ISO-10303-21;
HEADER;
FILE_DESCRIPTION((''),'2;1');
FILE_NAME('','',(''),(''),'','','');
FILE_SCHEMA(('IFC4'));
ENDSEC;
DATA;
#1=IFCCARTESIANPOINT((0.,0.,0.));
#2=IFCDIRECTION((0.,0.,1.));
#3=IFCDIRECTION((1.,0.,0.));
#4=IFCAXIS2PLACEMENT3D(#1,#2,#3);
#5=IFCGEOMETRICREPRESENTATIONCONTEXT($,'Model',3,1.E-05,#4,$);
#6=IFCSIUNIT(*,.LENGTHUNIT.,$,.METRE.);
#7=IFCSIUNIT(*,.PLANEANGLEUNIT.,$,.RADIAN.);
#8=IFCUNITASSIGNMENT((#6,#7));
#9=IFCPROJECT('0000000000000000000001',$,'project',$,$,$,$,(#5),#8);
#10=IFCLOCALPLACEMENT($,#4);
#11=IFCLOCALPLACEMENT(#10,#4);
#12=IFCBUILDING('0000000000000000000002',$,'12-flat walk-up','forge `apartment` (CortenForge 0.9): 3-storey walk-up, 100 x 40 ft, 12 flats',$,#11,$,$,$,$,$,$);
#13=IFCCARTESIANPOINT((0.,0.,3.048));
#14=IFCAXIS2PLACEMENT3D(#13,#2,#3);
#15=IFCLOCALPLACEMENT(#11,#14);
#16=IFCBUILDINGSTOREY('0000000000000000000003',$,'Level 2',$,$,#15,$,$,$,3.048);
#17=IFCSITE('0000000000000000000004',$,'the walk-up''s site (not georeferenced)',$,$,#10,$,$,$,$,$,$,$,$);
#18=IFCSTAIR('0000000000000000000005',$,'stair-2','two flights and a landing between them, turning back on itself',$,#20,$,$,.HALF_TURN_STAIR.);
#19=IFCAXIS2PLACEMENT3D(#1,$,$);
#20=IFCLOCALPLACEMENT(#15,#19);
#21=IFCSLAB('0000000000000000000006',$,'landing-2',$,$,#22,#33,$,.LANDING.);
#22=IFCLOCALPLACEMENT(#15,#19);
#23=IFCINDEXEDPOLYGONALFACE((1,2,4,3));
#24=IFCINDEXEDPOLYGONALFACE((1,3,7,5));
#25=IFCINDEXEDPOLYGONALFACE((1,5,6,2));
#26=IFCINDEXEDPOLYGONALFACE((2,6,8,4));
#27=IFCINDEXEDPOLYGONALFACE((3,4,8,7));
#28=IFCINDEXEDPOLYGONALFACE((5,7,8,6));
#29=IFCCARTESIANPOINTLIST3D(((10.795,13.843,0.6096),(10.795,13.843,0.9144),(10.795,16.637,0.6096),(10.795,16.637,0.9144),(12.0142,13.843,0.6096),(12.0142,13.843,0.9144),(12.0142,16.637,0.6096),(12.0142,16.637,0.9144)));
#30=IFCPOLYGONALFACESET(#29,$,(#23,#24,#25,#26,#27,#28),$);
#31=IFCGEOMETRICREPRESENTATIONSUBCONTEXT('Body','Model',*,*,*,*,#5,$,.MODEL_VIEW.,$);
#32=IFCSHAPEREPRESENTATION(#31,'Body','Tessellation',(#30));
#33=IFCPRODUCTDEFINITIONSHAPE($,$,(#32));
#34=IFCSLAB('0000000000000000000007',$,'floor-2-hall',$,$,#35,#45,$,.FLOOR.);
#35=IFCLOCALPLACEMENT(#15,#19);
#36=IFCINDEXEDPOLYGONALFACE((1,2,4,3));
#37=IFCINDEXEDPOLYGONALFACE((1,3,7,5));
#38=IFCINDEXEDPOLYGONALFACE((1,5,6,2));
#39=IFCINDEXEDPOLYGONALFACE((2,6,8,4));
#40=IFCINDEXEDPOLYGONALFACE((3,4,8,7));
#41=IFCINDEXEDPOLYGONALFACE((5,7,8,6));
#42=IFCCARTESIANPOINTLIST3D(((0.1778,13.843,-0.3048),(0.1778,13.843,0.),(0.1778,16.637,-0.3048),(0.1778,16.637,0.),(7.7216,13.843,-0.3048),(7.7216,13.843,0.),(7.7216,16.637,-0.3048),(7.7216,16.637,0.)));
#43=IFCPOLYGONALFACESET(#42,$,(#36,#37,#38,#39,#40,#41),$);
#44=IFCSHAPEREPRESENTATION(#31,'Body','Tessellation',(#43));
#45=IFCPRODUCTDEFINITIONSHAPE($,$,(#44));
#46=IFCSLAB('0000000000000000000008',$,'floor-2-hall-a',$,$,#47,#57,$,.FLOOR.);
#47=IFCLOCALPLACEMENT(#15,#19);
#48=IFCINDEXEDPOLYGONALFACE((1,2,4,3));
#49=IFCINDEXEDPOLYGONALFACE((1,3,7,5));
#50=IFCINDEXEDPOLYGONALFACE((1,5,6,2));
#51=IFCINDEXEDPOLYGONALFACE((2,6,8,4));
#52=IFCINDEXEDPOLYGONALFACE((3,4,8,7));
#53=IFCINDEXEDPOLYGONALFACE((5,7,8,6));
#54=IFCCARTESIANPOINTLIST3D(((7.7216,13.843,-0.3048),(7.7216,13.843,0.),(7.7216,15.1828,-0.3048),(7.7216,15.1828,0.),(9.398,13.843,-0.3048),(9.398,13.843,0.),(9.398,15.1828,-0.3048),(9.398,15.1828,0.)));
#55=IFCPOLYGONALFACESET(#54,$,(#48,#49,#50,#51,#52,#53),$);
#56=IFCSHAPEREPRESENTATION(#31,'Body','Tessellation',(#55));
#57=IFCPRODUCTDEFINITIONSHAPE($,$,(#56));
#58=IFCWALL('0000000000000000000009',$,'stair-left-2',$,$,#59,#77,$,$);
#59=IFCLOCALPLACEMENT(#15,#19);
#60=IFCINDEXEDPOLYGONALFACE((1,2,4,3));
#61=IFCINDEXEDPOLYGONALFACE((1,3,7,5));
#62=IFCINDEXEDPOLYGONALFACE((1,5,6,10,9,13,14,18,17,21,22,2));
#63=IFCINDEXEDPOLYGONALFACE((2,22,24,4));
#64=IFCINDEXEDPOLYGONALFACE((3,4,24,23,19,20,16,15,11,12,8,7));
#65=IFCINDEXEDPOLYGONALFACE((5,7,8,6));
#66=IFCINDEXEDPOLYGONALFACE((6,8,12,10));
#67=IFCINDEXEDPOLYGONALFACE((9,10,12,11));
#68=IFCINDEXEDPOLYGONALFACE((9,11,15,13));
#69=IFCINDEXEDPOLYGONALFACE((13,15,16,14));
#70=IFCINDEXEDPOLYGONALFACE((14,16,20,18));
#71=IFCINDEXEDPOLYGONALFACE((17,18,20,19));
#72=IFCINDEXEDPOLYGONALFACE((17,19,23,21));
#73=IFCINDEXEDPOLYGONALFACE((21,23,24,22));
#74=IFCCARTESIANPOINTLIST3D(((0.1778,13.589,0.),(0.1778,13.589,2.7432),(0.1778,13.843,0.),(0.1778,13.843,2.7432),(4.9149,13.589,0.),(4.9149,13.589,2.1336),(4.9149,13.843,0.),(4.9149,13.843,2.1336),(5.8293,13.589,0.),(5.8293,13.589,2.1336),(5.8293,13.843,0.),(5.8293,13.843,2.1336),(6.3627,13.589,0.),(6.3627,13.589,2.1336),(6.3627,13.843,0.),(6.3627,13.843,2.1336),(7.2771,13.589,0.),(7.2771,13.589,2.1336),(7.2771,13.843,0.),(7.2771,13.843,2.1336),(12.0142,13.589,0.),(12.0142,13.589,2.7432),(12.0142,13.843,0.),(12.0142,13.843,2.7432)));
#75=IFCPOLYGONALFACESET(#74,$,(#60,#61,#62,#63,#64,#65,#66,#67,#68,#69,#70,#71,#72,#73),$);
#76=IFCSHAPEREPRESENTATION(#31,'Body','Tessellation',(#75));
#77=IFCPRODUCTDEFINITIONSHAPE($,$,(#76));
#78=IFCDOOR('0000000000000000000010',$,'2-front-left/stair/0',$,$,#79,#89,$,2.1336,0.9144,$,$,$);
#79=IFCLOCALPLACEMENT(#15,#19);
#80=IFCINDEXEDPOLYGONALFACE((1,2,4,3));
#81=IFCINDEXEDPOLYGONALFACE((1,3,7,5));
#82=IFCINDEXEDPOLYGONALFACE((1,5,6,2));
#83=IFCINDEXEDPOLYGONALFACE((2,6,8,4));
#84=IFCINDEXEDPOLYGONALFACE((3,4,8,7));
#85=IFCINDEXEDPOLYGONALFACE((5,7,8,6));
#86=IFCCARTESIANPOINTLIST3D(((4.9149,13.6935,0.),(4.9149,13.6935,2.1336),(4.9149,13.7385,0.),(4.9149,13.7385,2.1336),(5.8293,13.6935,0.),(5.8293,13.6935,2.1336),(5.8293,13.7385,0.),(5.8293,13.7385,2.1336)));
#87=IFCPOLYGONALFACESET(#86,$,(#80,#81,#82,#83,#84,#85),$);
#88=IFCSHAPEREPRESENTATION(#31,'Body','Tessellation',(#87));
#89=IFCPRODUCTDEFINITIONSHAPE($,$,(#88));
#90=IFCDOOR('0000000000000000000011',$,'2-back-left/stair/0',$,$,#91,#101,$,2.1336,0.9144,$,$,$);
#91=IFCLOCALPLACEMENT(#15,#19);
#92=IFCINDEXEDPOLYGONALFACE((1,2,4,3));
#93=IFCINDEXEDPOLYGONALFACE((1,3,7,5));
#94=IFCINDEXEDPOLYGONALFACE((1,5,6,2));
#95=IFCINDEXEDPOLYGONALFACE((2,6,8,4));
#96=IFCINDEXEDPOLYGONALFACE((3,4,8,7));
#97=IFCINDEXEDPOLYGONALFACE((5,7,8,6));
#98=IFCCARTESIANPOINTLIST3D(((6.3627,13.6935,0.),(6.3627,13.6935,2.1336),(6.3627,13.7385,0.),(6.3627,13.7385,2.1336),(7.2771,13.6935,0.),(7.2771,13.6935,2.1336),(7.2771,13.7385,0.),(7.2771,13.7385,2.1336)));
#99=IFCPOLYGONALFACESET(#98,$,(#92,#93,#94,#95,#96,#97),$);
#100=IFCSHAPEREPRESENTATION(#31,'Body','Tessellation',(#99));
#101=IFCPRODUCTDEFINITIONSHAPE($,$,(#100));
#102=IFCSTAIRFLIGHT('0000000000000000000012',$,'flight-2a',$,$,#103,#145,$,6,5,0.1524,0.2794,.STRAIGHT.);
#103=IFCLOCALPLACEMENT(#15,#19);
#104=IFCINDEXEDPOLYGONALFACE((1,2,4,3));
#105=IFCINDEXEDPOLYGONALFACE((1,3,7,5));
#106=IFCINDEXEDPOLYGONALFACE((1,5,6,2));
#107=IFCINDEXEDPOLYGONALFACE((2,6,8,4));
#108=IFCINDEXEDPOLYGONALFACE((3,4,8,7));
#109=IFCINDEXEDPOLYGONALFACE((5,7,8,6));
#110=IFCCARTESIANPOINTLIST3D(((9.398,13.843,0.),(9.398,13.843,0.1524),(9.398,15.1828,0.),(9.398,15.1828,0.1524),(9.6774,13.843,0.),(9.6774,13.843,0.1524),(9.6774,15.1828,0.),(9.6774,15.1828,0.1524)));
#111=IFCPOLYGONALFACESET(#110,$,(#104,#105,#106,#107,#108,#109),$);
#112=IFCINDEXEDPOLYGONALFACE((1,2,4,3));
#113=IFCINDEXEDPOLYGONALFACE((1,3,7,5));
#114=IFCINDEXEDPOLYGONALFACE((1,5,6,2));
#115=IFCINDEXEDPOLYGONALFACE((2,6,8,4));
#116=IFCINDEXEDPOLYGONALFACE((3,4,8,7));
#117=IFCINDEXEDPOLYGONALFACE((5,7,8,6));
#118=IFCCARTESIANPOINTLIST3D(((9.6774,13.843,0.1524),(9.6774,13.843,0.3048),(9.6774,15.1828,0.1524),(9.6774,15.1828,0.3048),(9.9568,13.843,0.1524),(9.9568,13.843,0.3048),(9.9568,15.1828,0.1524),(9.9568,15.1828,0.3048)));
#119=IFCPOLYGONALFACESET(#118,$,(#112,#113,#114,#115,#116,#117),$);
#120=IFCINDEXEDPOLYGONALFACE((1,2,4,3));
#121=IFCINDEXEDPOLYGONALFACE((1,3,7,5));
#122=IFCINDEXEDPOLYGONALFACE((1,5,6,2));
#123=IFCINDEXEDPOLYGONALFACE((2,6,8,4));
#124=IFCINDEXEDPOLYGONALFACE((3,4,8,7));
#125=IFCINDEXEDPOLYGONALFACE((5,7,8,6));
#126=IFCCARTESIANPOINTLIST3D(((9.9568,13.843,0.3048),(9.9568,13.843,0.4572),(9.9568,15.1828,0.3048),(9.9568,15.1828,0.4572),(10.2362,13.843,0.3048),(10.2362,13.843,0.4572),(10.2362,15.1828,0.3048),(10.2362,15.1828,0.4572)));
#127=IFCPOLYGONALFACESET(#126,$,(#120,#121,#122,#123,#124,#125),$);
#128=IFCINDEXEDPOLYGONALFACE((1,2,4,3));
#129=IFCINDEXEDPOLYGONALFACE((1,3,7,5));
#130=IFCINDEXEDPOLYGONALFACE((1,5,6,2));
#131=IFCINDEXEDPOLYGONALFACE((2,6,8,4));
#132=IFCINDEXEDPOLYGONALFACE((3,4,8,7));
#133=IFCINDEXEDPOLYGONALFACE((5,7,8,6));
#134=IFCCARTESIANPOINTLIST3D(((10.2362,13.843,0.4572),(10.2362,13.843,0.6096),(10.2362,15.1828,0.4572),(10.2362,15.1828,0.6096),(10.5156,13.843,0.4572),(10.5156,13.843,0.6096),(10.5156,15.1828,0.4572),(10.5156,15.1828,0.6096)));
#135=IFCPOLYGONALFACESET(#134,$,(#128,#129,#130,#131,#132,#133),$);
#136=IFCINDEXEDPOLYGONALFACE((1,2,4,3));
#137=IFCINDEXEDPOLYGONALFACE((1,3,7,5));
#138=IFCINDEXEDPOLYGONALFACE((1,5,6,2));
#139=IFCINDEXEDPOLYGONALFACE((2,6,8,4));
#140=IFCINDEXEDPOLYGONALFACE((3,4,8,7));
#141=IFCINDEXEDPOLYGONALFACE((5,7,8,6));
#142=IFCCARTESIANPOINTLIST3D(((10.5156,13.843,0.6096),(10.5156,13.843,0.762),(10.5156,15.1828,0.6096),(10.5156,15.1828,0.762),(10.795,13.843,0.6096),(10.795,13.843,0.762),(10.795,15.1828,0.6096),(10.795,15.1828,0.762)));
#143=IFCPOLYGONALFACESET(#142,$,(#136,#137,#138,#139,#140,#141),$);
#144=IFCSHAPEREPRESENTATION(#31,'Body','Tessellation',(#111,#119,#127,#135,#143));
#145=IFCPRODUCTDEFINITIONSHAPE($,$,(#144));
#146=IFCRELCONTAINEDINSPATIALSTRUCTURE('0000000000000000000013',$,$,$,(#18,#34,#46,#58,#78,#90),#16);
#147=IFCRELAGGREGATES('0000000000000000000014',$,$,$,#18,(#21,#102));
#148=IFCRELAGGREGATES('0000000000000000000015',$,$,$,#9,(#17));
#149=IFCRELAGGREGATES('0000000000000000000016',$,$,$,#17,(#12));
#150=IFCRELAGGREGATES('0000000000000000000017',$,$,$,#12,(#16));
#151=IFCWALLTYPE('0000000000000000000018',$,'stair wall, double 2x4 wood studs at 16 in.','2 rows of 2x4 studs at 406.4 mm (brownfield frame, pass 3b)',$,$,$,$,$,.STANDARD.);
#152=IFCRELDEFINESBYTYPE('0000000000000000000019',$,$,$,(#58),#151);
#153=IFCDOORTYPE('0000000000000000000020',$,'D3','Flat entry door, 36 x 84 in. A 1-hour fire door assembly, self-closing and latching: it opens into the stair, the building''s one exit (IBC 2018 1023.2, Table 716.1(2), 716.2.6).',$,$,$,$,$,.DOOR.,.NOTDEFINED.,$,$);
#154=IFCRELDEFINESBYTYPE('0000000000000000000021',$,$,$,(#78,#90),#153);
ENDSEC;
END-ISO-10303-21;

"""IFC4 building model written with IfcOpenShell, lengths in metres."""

from ifc_helpers import new_model, si_unit, frame, frame_2d, origin, origin_with_axes, place, context, subcontext, project, spatial, rectangle, extrude, type_object, element, fill, aggregate, save


model = new_model("IFC4")

# Units and contexts
model_context = context("Model", 3, precision=1e-05, world=origin_with_axes())
body_context = subcontext(model_context, "Body", "Model", "MODEL_VIEW")
ifc_project = project(units=[si_unit("LENGTHUNIT", "METRE"), si_unit("PLANEANGLEUNIT", "RADIAN")], contexts=[model_context])

# Site, building, storey
site_placement = place(None, origin_with_axes())
site = spatial("IfcSite", under=ifc_project, at=site_placement, Name="the walk-up's site (not georeferenced)")
building_placement = place(site_placement, origin_with_axes())
building = spatial("IfcBuilding", under=site, at=building_placement, Name="12-flat walk-up", Description="forge `apartment` (CortenForge 0.9): 3-storey walk-up, 100 x 40 ft, 12 flats")
storey_placement = place(building_placement, frame((0.0, 0.0, 3.048), z_axis=(0.0, 0.0, 1.0), x_axis=(1.0, 0.0, 0.0)))
storey = spatial("IfcBuildingStorey", under=building, at=storey_placement, Name="Level 2", Elevation=3.048)

# Stair, slab
stair_placement = place(storey_placement, frame((0.0, 0.0, -3.048), z_axis=(0.0, 0.0, 1.0), x_axis=(1.0, 0.0, 0.0)))
stair = element("IfcStair", 1, at=stair_placement, inside=storey, Name="stair-2", Description="two flights and a landing between them, turning back on itself", PredefinedType="HALF_TURN_STAIR")
slab_1_placement = place(stair_placement, frame((10.795, 13.843, 3.6576), z_axis=(0.0, 0.0, 1.0), x_axis=(1.0, 0.0, 0.0)))
slab_1 = element("IfcSlab", 2, at=slab_1_placement, Name="landing-2", PredefinedType="LANDING", context=body_context, shape_type="SweptSolid", body=[
    extrude(rectangle(XDim=1.2192, YDim=2.794, at=frame_2d((0.6096, 1.397))), origin(), (0.0, 0.0, 1.0), 0.3048),
])

# Slabs
slab_2_placement = place(storey_placement, frame((0.1778, 13.843, -0.3048), z_axis=(0.0, 0.0, 1.0), x_axis=(1.0, 0.0, 0.0)))
element("IfcSlab", 3, at=slab_2_placement, inside=storey, Name="floor-2-hall", PredefinedType="FLOOR", context=body_context, shape_type="SweptSolid", body=[
    extrude(rectangle(XDim=7.5438, YDim=2.794, at=frame_2d((3.7719, 1.397))), origin(), (0.0, 0.0, 1.0), 0.3048),
])
slab_3_placement = place(storey_placement, frame((7.7216, 13.843, -0.3048), z_axis=(0.0, 0.0, 1.0), x_axis=(1.0, 0.0, 0.0)))
element("IfcSlab", 4, at=slab_3_placement, inside=storey, Name="floor-2-hall-a", PredefinedType="FLOOR", context=body_context, shape_type="SweptSolid", body=[
    extrude(rectangle(XDim=1.6764, YDim=1.3399, at=frame_2d((0.8382, 0.6699))), origin(), (0.0, 0.0, 1.0), 0.3048),
])

# Wall, openings, doors
wall_type = type_object("IfcWallType", Name="stair wall, double 2x4 wood studs at 16 in.", Description="2 rows of 2x4 studs at 406.4 mm (brownfield frame, pass 3b)", PredefinedType="STANDARD")
wall_placement = place(storey_placement, frame((0.1778, 13.589, 0.0), z_axis=(0.0, 0.0, 1.0), x_axis=(1.0, 0.0, 0.0)))
wall = element("IfcWall", 5, at=wall_placement, inside=storey, type_object=wall_type, Name="stair-left-2", context=body_context, shape_type="SweptSolid", body=[
    extrude(rectangle(XDim=11.8364, YDim=0.254, at=frame_2d((5.9182, 0.127))), origin(), (0.0, 0.0, 1.0), 2.7432),
])
opening_1_placement = place(wall_placement, frame((4.7371, 0.0, 0.0), z_axis=(0.0, 0.0, 1.0), x_axis=(1.0, 0.0, 0.0)))
opening_1 = element("IfcOpeningElement", 6, at=opening_1_placement, cuts=wall, PredefinedType="OPENING", context=body_context, shape_type="SweptSolid", body=[
    extrude(rectangle(XDim=0.9144, YDim=0.254, at=frame_2d((0.4572, 0.127))), origin(), (0.0, 0.0, 1.0), 2.1336),
])
opening_2_placement = place(wall_placement, frame((6.1849, 0.0, 0.0), z_axis=(0.0, 0.0, 1.0), x_axis=(1.0, 0.0, 0.0)))
opening_2 = element("IfcOpeningElement", 7, at=opening_2_placement, cuts=wall, PredefinedType="OPENING", context=body_context, shape_type="SweptSolid", body=[
    extrude(rectangle(XDim=0.9144, YDim=0.254, at=frame_2d((0.4572, 0.127))), origin(), (0.0, 0.0, 1.0), 2.1336),
])
door_type = type_object("IfcDoorType", Name="D3", Description="Flat entry door, 36 x 84 in. A 1-hour fire door assembly, self-closing and latching: it opens into the stair, the building's one exit (IBC 2018 1023.2, Table 716.1(2), 716.2.6).", OperationType="NOTDEFINED", PredefinedType="DOOR")
door_1_placement = place(opening_1_placement, frame((0.0, 0.1045, 0.0), z_axis=(0.0, 0.0, 1.0), x_axis=(1.0, 0.0, 0.0)))
door_1 = element("IfcDoor", 8, at=door_1_placement, inside=storey, type_object=door_type, Name="2-front-left/stair/0", OverallHeight=2.1336, OverallWidth=0.9144, context=body_context, shape_type="SweptSolid", body=[
    extrude(rectangle(XDim=0.9144, YDim=0.045, at=frame_2d((0.4572, 0.0225))), origin(), (0.0, 0.0, 1.0), 2.1336),
])
fill(opening_1, door_1)
door_2_placement = place(opening_2_placement, frame((0.0, 0.1045, 0.0), z_axis=(0.0, 0.0, 1.0), x_axis=(1.0, 0.0, 0.0)))
door_2 = element("IfcDoor", 9, at=door_2_placement, inside=storey, type_object=door_type, Name="2-back-left/stair/0", OverallHeight=2.1336, OverallWidth=0.9144, context=body_context, shape_type="SweptSolid", body=[
    extrude(rectangle(XDim=0.9144, YDim=0.045, at=frame_2d((0.4572, 0.0225))), origin(), (0.0, 0.0, 1.0), 2.1336),
])
fill(opening_2, door_2)

# Stair flight
stair_flight_placement = place(stair_placement, frame((9.398, 13.843, 3.048), z_axis=(0.0, 0.0, 1.0), x_axis=(1.0, 0.0, 0.0)))
stair_flight = element("IfcStairFlight", 10, at=stair_flight_placement, Name="flight-2a", NumberOfRisers=6, NumberOfTreads=5, PredefinedType="STRAIGHT", RiserHeight=0.1524, TreadLength=0.2794, context=body_context, shape_type="SweptSolid", body=[
    extrude(rectangle(XDim=0.2794, YDim=1.3399, at=frame_2d((0.1397, 0.6699))), origin(), (0.0, 0.0, 1.0), 0.1524),
    extrude(rectangle(XDim=0.2794, YDim=1.3399, at=frame_2d((0.1397, 0.6699))), frame((0.2794, 0.0, 0.1524)), (0.0, 0.0, 1.0), 0.1524),
    extrude(rectangle(XDim=0.2794, YDim=1.3399, at=frame_2d((0.1397, 0.6699))), frame((0.5588, 0.0, 0.3048)), (0.0, 0.0, 1.0), 0.1524),
    extrude(rectangle(XDim=0.2794, YDim=1.3399, at=frame_2d((0.1397, 0.6699))), frame((0.8382, 0.0, 0.4572)), (0.0, 0.0, 1.0), 0.1524),
    extrude(rectangle(XDim=0.2794, YDim=1.3399, at=frame_2d((0.1397, 0.6699))), frame((1.1176, 0.0, 0.6096)), (0.0, 0.0, 1.0), 0.1524),
])
aggregate(stair, [slab_1, stair_flight])

save(model, "model.ifc")
